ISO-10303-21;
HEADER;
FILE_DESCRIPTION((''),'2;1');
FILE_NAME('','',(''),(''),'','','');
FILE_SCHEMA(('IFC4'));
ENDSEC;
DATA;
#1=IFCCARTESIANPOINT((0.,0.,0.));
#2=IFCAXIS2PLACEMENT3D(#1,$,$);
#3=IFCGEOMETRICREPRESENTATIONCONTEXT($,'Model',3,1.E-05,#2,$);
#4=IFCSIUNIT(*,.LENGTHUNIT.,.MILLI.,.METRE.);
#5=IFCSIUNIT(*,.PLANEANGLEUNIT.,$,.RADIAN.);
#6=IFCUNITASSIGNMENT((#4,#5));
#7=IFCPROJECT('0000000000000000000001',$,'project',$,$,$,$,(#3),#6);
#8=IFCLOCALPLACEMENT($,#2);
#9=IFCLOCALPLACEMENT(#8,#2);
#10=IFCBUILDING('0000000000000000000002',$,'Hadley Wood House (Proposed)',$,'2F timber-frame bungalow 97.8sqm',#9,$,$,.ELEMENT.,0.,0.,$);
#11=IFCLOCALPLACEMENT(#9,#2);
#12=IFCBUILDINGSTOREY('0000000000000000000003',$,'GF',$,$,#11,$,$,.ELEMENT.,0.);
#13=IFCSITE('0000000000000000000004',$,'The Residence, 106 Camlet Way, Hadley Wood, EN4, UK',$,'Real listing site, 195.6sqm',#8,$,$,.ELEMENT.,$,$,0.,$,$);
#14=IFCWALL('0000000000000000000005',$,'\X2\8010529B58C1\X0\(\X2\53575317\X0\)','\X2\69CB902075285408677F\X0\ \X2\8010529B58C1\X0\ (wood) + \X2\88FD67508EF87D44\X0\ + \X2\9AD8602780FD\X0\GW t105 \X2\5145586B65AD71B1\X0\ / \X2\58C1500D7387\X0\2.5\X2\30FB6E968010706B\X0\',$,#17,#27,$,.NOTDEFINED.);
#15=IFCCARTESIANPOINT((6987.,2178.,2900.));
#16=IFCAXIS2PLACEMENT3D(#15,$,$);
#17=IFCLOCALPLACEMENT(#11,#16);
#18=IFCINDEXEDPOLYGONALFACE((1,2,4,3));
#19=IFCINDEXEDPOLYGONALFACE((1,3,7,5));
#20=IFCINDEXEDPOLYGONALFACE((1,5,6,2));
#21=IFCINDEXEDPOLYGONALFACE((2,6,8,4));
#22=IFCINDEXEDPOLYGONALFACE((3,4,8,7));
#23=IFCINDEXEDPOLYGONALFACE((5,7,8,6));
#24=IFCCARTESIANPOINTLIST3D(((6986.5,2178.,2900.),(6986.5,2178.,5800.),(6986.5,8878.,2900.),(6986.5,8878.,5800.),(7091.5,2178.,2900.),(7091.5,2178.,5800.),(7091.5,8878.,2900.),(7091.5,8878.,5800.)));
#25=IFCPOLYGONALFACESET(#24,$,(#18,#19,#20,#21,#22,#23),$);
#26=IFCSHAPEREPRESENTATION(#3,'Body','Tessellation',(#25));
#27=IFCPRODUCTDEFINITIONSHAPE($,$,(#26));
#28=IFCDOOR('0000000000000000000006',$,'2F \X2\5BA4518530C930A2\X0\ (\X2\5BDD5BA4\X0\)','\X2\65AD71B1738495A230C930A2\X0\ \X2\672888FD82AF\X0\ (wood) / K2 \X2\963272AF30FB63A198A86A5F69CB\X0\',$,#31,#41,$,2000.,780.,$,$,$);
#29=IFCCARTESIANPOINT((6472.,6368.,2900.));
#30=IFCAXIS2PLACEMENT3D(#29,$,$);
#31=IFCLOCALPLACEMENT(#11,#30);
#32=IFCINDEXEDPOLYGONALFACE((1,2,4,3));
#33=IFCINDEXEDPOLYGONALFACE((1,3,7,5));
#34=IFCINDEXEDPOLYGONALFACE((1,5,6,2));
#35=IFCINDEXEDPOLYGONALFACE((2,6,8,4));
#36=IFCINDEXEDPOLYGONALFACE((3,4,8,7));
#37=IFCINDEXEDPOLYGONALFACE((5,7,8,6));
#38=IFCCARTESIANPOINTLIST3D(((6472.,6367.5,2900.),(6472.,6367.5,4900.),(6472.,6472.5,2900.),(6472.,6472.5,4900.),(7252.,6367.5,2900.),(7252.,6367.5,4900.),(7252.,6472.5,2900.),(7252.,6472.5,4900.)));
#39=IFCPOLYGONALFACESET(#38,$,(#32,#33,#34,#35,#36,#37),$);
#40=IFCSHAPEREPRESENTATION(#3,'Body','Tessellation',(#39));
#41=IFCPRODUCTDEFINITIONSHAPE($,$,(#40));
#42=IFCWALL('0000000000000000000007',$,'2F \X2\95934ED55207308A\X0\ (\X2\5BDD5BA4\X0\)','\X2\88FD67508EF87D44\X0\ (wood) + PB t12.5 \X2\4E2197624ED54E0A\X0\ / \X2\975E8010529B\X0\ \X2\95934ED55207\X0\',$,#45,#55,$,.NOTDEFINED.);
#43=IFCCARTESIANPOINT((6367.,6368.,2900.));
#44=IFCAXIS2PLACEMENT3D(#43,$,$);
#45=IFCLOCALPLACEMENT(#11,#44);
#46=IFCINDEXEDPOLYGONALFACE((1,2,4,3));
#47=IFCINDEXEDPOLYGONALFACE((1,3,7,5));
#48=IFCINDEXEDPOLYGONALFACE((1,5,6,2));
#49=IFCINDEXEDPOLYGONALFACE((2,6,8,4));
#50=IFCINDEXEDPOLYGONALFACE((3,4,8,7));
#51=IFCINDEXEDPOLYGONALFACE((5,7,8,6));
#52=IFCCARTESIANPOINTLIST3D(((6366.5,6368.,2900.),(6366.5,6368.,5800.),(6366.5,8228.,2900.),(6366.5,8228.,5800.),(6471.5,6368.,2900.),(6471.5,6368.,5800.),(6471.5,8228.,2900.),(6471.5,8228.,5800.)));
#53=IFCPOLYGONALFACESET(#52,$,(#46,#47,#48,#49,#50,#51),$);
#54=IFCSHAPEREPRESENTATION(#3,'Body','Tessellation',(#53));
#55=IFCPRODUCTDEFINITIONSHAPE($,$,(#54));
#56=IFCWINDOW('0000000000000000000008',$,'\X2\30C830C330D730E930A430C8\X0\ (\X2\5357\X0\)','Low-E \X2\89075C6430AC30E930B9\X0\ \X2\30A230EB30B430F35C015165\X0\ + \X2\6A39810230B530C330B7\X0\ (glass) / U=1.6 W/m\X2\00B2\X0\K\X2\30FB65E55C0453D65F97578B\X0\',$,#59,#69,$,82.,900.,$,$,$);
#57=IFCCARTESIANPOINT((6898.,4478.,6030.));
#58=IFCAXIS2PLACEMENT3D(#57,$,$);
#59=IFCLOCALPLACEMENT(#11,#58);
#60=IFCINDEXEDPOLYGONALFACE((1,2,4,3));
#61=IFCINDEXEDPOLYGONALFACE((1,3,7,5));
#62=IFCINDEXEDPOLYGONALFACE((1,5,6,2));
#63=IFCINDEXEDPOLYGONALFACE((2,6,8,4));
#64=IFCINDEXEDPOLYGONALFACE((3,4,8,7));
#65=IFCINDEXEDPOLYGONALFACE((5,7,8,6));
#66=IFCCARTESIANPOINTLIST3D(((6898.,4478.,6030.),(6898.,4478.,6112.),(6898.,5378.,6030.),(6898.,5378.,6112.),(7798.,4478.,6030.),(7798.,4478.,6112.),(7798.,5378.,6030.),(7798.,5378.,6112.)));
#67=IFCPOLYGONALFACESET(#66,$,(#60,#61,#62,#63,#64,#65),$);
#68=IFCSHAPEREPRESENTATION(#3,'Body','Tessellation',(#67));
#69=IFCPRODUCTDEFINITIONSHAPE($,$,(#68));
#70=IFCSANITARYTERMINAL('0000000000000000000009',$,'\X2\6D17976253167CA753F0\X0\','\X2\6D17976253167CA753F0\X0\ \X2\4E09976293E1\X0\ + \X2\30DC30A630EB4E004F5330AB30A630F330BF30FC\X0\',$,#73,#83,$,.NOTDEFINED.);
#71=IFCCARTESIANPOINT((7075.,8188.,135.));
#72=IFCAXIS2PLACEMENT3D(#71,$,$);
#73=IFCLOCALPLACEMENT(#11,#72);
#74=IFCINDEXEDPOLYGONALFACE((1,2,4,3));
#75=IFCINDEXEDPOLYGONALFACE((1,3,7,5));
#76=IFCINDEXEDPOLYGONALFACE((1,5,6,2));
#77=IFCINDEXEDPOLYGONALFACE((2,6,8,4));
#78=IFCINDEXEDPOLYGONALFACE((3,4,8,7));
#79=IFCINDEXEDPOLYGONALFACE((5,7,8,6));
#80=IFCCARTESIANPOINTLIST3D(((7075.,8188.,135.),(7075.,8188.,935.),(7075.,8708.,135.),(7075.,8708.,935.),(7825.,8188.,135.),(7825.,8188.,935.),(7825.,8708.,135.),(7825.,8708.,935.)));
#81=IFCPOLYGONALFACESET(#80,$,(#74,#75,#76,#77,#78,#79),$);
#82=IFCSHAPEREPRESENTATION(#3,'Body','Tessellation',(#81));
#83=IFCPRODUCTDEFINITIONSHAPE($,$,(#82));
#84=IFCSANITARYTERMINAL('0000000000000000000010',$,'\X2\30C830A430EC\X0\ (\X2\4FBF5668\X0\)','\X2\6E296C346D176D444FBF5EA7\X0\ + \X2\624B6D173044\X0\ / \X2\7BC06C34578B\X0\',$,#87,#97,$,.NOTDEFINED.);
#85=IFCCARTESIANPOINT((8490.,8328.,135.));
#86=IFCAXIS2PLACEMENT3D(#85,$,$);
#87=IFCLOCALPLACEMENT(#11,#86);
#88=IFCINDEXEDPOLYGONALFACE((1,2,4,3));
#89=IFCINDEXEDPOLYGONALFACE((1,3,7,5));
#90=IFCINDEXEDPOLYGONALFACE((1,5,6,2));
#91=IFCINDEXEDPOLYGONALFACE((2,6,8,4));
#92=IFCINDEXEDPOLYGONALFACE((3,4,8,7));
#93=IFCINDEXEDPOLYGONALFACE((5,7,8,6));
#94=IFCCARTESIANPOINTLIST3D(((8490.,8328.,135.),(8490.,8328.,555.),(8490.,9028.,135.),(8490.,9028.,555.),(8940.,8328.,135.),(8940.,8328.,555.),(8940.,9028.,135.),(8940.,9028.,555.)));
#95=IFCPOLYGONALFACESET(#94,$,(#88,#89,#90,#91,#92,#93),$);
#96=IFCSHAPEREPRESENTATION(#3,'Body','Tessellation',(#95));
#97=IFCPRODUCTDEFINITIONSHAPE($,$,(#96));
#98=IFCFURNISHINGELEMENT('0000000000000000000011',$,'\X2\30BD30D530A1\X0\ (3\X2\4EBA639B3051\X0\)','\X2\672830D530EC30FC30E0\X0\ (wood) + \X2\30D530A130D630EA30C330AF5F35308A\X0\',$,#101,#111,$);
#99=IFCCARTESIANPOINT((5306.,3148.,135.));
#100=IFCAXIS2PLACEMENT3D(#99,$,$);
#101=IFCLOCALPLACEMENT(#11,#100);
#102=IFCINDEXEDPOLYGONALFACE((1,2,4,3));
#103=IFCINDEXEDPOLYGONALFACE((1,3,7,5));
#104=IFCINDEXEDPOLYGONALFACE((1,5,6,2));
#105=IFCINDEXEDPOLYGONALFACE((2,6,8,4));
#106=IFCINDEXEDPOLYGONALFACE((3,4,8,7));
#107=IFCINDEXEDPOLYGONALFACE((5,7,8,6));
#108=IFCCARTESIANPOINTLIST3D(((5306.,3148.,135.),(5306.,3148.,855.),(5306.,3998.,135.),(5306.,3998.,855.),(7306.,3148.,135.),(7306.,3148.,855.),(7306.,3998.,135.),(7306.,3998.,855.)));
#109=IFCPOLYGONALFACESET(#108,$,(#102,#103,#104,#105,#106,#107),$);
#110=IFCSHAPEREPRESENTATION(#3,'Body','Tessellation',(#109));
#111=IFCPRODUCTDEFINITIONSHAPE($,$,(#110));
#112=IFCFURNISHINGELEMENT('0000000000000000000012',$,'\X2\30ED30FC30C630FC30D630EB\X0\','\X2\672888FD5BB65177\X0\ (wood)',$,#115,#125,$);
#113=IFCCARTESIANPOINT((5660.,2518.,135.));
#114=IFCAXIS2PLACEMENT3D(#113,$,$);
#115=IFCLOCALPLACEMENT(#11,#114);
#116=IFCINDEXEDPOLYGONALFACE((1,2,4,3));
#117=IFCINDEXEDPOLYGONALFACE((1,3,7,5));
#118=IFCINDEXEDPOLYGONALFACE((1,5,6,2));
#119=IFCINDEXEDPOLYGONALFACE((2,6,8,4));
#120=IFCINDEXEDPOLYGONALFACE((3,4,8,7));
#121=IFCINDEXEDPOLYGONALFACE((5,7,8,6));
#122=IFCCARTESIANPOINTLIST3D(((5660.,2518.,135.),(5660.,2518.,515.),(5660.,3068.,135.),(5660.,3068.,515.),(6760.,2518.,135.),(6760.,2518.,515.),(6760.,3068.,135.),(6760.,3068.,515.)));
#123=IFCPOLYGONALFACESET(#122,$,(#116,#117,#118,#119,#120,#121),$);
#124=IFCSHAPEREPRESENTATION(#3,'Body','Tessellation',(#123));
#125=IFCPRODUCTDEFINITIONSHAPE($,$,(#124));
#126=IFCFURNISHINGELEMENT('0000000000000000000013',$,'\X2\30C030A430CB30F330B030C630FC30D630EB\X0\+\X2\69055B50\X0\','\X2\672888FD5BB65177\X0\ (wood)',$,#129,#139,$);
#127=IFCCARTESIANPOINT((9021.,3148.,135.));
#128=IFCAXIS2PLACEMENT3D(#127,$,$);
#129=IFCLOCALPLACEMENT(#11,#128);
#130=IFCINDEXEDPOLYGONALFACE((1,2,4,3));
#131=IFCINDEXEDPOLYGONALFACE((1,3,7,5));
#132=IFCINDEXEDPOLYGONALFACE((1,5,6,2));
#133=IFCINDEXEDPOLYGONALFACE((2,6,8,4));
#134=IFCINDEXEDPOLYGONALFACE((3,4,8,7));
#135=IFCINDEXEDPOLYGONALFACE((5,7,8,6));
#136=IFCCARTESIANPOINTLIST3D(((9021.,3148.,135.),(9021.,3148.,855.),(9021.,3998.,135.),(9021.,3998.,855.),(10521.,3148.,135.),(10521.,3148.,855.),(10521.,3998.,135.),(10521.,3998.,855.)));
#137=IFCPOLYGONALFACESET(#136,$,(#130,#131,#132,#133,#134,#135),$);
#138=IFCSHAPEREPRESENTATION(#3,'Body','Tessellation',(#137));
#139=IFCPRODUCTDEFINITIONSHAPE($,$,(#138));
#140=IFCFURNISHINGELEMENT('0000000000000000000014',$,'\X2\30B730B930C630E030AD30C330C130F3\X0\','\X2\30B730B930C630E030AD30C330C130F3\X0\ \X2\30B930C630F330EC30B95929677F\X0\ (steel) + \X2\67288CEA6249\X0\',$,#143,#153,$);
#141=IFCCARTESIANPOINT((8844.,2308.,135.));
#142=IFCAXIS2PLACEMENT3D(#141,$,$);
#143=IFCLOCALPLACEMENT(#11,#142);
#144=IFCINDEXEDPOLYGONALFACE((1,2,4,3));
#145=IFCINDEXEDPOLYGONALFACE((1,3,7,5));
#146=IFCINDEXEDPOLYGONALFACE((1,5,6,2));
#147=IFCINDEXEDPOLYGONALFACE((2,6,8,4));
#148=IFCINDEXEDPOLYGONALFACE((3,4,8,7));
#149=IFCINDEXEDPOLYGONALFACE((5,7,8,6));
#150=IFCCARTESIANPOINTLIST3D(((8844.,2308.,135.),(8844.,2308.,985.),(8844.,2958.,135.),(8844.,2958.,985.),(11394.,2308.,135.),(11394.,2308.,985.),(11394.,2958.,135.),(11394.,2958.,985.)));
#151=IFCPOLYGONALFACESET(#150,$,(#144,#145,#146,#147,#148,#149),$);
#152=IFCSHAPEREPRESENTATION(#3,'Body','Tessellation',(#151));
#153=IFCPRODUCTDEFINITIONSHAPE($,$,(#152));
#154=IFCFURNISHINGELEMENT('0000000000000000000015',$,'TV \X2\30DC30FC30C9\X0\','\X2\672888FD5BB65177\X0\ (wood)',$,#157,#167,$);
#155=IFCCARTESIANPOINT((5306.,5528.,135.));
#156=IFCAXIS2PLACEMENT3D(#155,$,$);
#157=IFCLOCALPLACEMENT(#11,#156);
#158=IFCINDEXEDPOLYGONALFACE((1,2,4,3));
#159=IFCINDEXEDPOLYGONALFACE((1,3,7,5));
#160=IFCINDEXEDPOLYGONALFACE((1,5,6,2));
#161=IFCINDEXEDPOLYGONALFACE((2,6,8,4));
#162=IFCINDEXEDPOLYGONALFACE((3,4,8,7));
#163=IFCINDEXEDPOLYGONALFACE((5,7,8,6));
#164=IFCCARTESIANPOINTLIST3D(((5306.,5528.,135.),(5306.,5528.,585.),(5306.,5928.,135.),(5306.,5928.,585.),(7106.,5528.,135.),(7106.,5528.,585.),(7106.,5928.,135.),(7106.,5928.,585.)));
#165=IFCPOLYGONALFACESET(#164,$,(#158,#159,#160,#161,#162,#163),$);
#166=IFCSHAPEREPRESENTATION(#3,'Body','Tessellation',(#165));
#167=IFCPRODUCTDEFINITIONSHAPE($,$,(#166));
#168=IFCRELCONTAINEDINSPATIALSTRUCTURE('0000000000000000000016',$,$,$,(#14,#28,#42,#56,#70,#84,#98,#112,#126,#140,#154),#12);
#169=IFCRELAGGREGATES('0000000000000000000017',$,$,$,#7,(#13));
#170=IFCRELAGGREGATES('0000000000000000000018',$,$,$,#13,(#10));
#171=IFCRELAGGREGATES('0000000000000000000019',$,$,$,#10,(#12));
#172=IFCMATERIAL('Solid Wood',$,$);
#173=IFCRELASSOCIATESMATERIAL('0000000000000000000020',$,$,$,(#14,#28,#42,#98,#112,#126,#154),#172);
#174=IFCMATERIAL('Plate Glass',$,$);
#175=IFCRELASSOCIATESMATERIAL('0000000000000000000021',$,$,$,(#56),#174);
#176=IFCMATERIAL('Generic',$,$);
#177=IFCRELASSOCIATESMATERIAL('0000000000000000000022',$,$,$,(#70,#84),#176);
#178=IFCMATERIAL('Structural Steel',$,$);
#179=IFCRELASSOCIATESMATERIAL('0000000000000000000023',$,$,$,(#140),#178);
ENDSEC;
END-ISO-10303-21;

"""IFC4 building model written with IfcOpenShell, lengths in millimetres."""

from ifc_helpers import new_model, si_unit, frame, frame_2d, origin, place, context, project, spatial, rectangle, extrude, material, element, fill, save


model = new_model("IFC4")

# Units and contexts
model_context = context("Model", 3, precision=1e-05, world=origin())
ifc_project = project(units=[si_unit("LENGTHUNIT", "METRE", prefix="MILLI"), si_unit("PLANEANGLEUNIT", "RADIAN")], contexts=[model_context])

# Site, building, storey
site_placement = place(None, origin())
site = spatial("IfcSite", under=ifc_project, at=site_placement, Name="The Residence, 106 Camlet Way, Hadley Wood, EN4, UK", ObjectType="Real listing site, 195.6sqm", CompositionType="ELEMENT", RefElevation=0.0)
building_placement = place(site_placement, origin())
building = spatial("IfcBuilding", under=site, at=building_placement, Name="Hadley Wood House (Proposed)", ObjectType="2F timber-frame bungalow 97.8sqm", CompositionType="ELEMENT", ElevationOfRefHeight=0.0, ElevationOfTerrain=0.0)
storey_placement = place(building_placement, origin())
storey = spatial("IfcBuildingStorey", under=building, at=storey_placement, Name="GF", CompositionType="ELEMENT", Elevation=0.0)

# Shared definitions
ifc_material_1 = material(Name="Solid Wood")

# Wall, opening, door
wall_1_placement = place(storey_placement, frame((6987.0, 2178.0, 2900.0)))
wall_1 = element("IfcWall", 1, at=wall_1_placement, inside=storey, material=ifc_material_1, Name="耐力壁(南北)", Description="構造用合板 耐力壁 (wood) + 製材軸組 + 高性能GW t105 充填断熱 / 壁倍率2.5・準耐火", PredefinedType="NOTDEFINED", context=model_context, shape_type="SweptSolid", body=[
    extrude(rectangle(XDim=105.0, YDim=6700.0, at=frame_2d((52.0, 3350.0))), frame((6987.0, 2178.0, 2900.0)), (0.0, 0.0, 1.0), 2900.0),
])
opening_1_placement = place(storey_placement, frame((6472.0, 6368.0, 2900.0)))
opening_1 = element("IfcOpeningElement", 2, at=opening_1_placement, cuts=wall_1, PredefinedType="NOTDEFINED", context=model_context, shape_type="SweptSolid", body=[
    extrude(rectangle(XDim=780.0, YDim=105.0, at=frame_2d((390.0, 52.0))), frame((6472.0, 6368.0, 2900.0)), (0.0, 0.0, 1.0), 2000.0),
])
door_1_placement = place(storey_placement, frame((6472.0, 6368.0, 2900.0)))
door_1 = element("IfcDoor", 3, at=door_1_placement, inside=storey, material=ifc_material_1, Name="2F 室内ドア (寝室)", Description="断熱玄関ドア 木製芯 (wood) / K2 防犯・採風機構", OverallHeight=2000.0, OverallWidth=780.0, context=model_context, shape_type="SweptSolid", body=[
    extrude(rectangle(XDim=780.0, YDim=105.0, at=frame_2d((390.0, 52.0))), frame((6472.0, 6368.0, 2900.0)), (0.0, 0.0, 1.0), 2000.0),
])
fill(opening_1, door_1)

# Wall
wall_2_placement = place(storey_placement, frame((6367.0, 6368.0, 2900.0)))
element("IfcWall", 4, at=wall_2_placement, inside=storey, material=ifc_material_1, Name="2F 間仕切り (寝室)", Description="製材軸組 (wood) + PB t12.5 両面仕上 / 非耐力 間仕切", PredefinedType="NOTDEFINED", context=model_context, shape_type="SweptSolid", body=[
    extrude(rectangle(XDim=105.0, YDim=1860.0, at=frame_2d((52.0, 930.0))), frame((6367.0, 6368.0, 2900.0)), (0.0, 0.0, 1.0), 2900.0),
])

# Window
ifc_material_2 = material(Name="Plate Glass")
window_placement = place(storey_placement, frame((6898.0, 4478.0, 6030.0)))
element("IfcWindow", 5, at=window_placement, inside=storey, material=ifc_material_2, Name="トップライト (南)", Description="Low-E 複層ガラス アルゴン封入 + 樹脂サッシ (glass) / U=1.6 W/m²K・日射取得型", OverallHeight=82.0, OverallWidth=900.0, context=model_context, shape_type="SweptSolid", body=[
    extrude(rectangle(XDim=900.0, YDim=900.0, at=frame_2d((450.0, 450.0))), frame((6898.0, 4478.0, 6030.0)), (0.0, 0.0, 1.0), 82.0),
])

# Sanitary terminals
ifc_material_3 = material(Name="Generic")
sanitary_terminal_1_placement = place(storey_placement, frame((7075.0, 8188.0, 135.0)))
element("IfcSanitaryTerminal", 6, at=sanitary_terminal_1_placement, inside=storey, material=ifc_material_3, Name="洗面化粧台", Description="洗面化粧台 三面鏡 + ボウル一体カウンター", PredefinedType="NOTDEFINED", context=model_context, shape_type="SweptSolid", body=[
    extrude(rectangle(XDim=750.0, YDim=520.0, at=frame_2d((375.0, 260.0))), frame((7075.0, 8188.0, 135.0)), (0.0, 0.0, 1.0), 800.0),
])
sanitary_terminal_2_placement = place(storey_placement, frame((8490.0, 8328.0, 135.0)))
element("IfcSanitaryTerminal", 7, at=sanitary_terminal_2_placement, inside=storey, material=ifc_material_3, Name="トイレ (便器)", Description="温水洗浄便座 + 手洗い / 節水型", PredefinedType="NOTDEFINED", context=model_context, shape_type="SweptSolid", body=[
    extrude(rectangle(XDim=450.0, YDim=700.0, at=frame_2d((225.0, 350.0))), frame((8490.0, 8328.0, 135.0)), (0.0, 0.0, 1.0), 420.0),
])

# Furnishing elements
furnishing_1_placement = place(storey_placement, frame((5306.0, 3148.0, 135.0)))
element("IfcFurnishingElement", 8, at=furnishing_1_placement, inside=storey, material=ifc_material_1, Name="ソファ (3人掛け)", Description="木フレーム (wood) + ファブリック張り", context=model_context, shape_type="SweptSolid", body=[
    extrude(rectangle(XDim=2000.0, YDim=850.0, at=frame_2d((1000.0, 425.0))), frame((5306.0, 3148.0, 135.0)), (0.0, 0.0, 1.0), 720.0),
])
furnishing_2_placement = place(storey_placement, frame((5660.0, 2518.0, 135.0)))
element("IfcFurnishingElement", 9, at=furnishing_2_placement, inside=storey, material=ifc_material_1, Name="ローテーブル", Description="木製家具 (wood)", context=model_context, shape_type="SweptSolid", body=[
    extrude(rectangle(XDim=1100.0, YDim=550.0, at=frame_2d((550.0, 275.0))), frame((5660.0, 2518.0, 135.0)), (0.0, 0.0, 1.0), 380.0),
])
furnishing_3_placement = place(storey_placement, frame((9021.0, 3148.0, 135.0)))
element("IfcFurnishingElement", 10, at=furnishing_3_placement, inside=storey, material=ifc_material_1, Name="ダイニングテーブル+椅子", Description="木製家具 (wood)", context=model_context, shape_type="SweptSolid", body=[
    extrude(rectangle(XDim=1500.0, YDim=850.0, at=frame_2d((750.0, 425.0))), frame((9021.0, 3148.0, 135.0)), (0.0, 0.0, 1.0), 720.0),
])
ifc_material_4 = material(Name="Structural Steel")
furnishing_4_placement = place(storey_placement, frame((8844.0, 2308.0, 135.0)))
element("IfcFurnishingElement", 11, at=furnishing_4_placement, inside=storey, material=ifc_material_4, Name="システムキッチン", Description="システムキッチン ステンレス天板 (steel) + 木質扉", context=model_context, shape_type="SweptSolid", body=[
    extrude(rectangle(XDim=2550.0, YDim=650.0, at=frame_2d((1275.0, 325.0))), frame((8844.0, 2308.0, 135.0)), (0.0, 0.0, 1.0), 850.0),
])
furnishing_5_placement = place(storey_placement, frame((5306.0, 5528.0, 135.0)))
element("IfcFurnishingElement", 12, at=furnishing_5_placement, inside=storey, material=ifc_material_1, Name="TV ボード", Description="木製家具 (wood)", context=model_context, shape_type="SweptSolid", body=[
    extrude(rectangle(XDim=1800.0, YDim=400.0, at=frame_2d((900.0, 200.0))), frame((5306.0, 5528.0, 135.0)), (0.0, 0.0, 1.0), 450.0),
])

save(model, "model.ifc")
